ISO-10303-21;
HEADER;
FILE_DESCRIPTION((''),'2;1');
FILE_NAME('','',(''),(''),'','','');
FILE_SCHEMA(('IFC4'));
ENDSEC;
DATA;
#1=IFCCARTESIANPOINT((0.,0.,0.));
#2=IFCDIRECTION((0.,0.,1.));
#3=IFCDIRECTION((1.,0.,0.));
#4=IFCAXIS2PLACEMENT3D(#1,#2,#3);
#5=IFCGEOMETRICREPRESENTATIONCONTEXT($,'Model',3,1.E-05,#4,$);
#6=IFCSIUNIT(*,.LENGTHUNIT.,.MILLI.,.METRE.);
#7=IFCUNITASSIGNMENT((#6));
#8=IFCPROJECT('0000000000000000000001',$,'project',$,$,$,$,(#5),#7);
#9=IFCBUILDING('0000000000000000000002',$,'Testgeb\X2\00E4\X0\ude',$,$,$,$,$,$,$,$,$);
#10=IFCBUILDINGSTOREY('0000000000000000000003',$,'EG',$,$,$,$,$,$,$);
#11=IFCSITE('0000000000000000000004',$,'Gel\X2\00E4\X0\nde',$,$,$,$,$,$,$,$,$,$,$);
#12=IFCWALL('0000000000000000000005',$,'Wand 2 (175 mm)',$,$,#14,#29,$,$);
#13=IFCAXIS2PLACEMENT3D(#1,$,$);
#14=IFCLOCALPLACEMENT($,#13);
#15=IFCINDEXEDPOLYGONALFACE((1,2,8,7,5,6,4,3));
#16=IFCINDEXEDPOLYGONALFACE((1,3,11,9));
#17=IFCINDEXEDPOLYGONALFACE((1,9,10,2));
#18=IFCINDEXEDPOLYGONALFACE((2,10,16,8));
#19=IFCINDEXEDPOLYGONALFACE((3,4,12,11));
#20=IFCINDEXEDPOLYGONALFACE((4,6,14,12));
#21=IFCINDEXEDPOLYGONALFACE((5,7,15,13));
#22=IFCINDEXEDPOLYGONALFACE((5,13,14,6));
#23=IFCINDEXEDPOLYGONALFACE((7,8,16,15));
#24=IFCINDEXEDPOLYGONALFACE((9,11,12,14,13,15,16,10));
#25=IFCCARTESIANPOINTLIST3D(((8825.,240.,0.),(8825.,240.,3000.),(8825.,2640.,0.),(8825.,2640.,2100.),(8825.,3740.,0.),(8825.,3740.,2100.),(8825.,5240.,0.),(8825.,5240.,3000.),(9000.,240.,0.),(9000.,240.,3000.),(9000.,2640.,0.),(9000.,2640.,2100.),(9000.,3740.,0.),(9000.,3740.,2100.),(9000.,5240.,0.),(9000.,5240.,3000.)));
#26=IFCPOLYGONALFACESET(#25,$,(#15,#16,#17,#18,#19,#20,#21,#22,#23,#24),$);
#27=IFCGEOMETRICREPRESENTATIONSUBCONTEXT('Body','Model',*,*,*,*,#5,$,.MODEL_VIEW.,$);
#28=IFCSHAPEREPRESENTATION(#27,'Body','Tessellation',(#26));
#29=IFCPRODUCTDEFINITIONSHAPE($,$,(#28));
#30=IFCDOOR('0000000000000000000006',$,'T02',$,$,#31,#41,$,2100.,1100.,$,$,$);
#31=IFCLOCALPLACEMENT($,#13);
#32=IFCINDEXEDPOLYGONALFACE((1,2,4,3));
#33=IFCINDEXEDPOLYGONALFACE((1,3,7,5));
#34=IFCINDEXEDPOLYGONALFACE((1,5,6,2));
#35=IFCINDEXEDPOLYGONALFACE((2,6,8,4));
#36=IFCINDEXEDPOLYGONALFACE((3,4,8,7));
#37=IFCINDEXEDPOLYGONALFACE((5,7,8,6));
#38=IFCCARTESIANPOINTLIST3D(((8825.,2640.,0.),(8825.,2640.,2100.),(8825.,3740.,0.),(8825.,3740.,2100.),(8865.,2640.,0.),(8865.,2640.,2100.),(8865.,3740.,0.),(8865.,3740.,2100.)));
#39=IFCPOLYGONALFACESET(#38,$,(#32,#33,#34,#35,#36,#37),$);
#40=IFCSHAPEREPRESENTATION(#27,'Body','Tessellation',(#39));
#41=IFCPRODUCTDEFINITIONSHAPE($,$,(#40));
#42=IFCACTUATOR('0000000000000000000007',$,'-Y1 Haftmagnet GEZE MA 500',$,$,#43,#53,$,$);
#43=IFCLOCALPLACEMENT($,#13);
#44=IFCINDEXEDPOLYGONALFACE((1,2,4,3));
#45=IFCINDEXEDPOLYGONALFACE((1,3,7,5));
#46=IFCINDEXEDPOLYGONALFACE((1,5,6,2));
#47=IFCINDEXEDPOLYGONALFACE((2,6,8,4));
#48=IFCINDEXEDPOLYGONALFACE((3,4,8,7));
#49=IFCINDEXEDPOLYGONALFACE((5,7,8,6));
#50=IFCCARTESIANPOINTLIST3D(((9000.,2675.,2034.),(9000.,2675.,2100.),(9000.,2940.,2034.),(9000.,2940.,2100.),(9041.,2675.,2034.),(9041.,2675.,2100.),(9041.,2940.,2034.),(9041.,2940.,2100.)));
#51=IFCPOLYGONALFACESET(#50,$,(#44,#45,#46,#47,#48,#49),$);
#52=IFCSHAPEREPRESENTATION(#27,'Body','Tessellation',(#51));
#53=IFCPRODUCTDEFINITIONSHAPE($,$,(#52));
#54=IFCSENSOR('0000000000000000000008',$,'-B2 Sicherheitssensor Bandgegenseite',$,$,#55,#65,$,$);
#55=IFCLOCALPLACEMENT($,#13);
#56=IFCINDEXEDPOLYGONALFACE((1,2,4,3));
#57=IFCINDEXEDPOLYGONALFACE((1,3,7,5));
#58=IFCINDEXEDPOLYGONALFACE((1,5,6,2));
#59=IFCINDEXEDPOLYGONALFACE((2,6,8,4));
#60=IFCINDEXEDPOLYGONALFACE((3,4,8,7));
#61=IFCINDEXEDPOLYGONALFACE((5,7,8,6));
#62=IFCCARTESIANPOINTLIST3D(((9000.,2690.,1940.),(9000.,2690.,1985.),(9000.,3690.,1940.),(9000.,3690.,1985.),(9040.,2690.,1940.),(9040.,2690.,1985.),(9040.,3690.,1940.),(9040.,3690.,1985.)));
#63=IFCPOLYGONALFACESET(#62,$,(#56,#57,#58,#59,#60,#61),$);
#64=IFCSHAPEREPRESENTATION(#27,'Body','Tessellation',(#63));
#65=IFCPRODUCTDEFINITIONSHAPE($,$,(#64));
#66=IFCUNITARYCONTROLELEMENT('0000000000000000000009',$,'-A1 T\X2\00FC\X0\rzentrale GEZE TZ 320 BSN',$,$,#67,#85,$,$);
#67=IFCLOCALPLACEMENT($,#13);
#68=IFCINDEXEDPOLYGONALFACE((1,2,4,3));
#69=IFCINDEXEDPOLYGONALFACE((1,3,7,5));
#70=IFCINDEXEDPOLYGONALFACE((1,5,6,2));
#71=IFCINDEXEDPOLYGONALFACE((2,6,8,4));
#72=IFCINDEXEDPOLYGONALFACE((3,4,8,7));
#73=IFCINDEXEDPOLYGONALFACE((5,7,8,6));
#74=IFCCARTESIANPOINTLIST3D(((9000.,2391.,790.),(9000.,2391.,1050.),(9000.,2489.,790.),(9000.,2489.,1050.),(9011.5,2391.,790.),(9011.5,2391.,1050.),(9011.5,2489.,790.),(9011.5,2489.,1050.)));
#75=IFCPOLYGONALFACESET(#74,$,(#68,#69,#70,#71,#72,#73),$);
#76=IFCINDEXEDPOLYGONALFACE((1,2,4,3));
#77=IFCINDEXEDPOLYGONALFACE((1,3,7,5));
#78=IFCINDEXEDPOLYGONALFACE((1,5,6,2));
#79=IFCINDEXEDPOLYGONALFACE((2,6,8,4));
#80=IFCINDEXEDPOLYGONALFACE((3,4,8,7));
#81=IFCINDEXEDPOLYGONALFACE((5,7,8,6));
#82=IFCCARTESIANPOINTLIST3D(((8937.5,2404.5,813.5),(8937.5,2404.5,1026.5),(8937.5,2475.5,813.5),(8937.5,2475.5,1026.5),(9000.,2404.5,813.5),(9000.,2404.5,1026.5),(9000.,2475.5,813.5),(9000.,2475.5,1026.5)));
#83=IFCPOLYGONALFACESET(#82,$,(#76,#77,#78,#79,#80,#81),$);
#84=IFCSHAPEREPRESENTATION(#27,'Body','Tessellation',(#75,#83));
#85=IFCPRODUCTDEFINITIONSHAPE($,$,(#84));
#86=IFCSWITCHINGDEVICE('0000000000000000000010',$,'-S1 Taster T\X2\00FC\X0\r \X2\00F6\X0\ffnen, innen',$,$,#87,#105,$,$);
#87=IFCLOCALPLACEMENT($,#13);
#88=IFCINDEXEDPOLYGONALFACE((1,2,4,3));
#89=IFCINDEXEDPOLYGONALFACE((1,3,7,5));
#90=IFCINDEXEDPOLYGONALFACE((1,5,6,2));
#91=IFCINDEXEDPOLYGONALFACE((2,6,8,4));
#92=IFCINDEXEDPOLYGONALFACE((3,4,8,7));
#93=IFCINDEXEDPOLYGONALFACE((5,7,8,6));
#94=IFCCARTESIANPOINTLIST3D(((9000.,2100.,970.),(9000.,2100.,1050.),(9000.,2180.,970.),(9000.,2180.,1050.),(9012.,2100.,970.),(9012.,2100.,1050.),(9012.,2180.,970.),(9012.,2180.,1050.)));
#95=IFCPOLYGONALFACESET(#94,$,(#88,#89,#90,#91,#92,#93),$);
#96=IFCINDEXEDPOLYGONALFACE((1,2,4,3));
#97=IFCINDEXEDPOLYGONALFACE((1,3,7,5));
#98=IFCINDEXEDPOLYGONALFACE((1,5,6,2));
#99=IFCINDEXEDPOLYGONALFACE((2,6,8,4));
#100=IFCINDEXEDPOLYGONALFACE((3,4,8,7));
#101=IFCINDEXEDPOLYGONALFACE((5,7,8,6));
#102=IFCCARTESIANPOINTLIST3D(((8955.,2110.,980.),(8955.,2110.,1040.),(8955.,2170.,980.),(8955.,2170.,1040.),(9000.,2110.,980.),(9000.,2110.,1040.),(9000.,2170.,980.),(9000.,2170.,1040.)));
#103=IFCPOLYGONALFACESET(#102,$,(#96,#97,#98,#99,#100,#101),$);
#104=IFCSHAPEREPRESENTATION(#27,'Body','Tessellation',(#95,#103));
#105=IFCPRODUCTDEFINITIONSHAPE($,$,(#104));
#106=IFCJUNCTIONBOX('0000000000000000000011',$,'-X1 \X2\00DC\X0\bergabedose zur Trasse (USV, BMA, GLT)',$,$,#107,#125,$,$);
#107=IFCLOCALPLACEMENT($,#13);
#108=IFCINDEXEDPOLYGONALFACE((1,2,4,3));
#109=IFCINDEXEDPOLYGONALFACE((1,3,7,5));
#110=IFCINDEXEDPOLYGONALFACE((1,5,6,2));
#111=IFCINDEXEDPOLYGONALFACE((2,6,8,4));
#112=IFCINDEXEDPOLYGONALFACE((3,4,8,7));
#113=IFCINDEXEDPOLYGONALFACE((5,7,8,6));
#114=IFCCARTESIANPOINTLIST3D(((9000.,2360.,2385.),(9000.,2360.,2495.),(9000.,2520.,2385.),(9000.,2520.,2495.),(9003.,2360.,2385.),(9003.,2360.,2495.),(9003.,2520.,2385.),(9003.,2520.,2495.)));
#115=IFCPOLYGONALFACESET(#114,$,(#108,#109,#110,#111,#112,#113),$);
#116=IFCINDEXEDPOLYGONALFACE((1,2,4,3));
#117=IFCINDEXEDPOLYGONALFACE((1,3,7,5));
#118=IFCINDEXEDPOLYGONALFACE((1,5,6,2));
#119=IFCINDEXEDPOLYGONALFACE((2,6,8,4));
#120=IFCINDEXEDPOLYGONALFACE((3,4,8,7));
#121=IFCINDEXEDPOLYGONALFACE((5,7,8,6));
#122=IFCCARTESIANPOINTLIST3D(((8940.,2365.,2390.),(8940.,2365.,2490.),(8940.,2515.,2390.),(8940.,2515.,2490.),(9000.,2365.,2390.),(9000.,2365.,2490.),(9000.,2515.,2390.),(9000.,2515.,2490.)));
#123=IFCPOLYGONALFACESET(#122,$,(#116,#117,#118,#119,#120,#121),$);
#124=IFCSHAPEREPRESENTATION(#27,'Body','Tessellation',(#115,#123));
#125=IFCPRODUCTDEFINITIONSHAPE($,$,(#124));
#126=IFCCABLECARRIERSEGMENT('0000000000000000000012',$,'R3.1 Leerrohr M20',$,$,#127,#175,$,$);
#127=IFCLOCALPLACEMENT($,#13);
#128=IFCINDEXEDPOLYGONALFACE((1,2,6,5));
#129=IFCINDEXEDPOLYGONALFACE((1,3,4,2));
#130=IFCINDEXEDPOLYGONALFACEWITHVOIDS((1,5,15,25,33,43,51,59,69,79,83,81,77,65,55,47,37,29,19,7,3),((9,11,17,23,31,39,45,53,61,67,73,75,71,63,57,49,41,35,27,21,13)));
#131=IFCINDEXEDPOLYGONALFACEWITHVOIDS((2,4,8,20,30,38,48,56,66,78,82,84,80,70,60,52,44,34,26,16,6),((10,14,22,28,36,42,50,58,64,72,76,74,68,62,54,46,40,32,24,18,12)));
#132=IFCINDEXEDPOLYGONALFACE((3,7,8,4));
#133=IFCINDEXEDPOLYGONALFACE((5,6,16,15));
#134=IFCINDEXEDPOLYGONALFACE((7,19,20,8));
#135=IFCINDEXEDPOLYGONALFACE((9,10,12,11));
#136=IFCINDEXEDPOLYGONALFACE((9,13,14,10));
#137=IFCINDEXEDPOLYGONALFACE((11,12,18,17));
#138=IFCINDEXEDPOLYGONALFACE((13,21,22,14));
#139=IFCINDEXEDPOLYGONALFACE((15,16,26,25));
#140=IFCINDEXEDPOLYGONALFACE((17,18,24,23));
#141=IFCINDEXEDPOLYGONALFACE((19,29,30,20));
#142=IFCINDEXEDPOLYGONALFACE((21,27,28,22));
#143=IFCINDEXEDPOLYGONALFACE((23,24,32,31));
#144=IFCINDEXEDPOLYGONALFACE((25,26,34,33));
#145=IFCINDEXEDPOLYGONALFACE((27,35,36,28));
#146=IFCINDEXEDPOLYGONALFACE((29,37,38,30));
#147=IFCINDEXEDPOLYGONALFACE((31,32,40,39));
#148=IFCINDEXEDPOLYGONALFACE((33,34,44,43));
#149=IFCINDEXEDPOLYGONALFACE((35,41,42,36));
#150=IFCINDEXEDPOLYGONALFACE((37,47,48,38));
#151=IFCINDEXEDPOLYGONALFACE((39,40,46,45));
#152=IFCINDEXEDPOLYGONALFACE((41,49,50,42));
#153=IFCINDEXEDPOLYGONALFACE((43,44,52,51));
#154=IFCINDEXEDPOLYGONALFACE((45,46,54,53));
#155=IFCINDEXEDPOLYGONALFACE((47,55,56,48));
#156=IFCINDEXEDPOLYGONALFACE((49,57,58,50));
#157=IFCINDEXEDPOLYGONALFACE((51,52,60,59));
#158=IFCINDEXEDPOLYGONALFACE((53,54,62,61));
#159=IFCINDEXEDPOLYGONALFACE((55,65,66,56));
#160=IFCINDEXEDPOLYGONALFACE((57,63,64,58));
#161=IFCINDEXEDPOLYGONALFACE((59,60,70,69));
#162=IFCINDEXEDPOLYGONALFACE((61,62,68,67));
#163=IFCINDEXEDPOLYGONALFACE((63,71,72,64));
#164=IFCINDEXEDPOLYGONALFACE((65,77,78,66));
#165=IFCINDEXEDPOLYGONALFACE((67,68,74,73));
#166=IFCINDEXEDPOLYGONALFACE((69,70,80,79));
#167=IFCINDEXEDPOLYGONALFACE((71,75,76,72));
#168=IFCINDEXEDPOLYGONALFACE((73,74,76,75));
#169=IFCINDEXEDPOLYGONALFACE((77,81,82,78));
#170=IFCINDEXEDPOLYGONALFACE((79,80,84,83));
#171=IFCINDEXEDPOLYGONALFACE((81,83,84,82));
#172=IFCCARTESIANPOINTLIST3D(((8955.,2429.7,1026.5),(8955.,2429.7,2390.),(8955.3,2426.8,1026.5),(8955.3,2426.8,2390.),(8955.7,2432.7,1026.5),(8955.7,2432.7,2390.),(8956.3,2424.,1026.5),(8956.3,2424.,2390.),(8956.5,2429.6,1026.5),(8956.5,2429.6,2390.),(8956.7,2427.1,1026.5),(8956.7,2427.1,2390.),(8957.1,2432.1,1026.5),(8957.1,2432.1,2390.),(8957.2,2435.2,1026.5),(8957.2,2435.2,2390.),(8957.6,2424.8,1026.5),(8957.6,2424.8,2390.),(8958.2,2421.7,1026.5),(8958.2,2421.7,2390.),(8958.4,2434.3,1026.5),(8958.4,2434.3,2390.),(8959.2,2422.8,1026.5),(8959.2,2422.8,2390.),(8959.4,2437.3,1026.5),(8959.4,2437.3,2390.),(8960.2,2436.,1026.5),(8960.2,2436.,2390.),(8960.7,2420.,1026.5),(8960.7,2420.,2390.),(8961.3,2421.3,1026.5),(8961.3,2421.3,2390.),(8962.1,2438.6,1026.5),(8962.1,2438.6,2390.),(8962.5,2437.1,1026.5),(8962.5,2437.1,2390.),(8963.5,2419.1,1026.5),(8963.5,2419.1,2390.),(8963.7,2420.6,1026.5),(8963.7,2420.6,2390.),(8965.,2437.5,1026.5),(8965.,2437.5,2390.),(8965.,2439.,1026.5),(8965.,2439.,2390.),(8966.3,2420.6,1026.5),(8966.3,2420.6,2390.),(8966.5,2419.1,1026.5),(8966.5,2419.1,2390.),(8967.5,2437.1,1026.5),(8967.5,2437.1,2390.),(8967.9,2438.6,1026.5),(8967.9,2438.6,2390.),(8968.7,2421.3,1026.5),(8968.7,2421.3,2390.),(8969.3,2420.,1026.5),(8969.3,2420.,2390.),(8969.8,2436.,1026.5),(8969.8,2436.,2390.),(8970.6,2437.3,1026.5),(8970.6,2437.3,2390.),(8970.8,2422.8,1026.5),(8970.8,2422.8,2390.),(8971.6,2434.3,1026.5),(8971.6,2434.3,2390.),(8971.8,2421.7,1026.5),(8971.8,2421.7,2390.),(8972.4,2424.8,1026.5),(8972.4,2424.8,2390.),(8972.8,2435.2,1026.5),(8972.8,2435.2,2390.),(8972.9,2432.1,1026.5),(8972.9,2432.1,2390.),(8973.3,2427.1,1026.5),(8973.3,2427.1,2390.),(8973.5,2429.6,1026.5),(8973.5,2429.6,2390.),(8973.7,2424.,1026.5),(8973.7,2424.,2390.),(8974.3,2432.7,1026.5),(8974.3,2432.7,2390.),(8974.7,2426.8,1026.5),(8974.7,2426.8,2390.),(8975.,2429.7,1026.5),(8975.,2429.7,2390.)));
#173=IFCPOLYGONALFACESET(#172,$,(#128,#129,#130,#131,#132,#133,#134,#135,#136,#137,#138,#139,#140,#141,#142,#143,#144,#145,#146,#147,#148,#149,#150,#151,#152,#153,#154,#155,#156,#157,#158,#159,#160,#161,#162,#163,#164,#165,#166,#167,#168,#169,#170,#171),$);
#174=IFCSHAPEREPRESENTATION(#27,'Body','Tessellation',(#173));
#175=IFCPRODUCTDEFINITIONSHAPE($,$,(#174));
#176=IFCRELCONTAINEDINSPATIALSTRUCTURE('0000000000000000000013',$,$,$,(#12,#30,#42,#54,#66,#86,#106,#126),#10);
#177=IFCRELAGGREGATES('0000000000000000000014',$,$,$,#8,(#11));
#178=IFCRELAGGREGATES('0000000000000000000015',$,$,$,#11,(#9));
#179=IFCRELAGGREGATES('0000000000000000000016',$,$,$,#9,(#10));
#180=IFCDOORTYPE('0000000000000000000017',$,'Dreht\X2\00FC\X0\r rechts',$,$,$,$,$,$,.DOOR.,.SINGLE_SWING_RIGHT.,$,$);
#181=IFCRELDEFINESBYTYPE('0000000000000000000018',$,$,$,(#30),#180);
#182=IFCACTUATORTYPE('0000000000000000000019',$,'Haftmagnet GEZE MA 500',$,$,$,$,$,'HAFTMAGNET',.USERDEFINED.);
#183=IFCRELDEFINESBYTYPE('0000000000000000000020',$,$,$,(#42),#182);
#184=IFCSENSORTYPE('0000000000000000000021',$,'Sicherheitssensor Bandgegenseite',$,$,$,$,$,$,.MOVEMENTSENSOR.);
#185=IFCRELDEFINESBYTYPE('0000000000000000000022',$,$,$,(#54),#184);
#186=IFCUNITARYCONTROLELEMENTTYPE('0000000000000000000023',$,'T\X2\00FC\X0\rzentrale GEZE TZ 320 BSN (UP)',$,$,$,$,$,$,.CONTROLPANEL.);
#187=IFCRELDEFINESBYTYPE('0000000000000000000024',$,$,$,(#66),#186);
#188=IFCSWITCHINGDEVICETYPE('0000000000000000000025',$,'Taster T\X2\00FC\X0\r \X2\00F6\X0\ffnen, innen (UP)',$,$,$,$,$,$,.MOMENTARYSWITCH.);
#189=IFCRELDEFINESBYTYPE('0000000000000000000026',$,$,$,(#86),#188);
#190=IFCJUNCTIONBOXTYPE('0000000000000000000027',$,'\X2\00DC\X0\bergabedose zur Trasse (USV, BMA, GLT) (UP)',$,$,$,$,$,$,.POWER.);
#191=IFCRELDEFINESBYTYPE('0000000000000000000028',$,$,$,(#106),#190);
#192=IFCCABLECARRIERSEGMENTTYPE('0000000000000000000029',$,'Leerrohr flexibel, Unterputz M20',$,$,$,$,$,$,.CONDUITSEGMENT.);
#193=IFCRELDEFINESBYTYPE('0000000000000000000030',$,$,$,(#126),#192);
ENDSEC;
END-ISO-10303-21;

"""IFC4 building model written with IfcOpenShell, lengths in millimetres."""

from ifc_helpers import new_model, si_unit, frame, frame_2d, origin_with_axes, place, context, subcontext, project, spatial, rectangle, hollow_circle, extrude, type_object, element, fill, save


model = new_model("IFC4")

# Units and contexts
model_context = context("Model", 3, precision=1e-05, world=origin_with_axes())
body_context = subcontext(model_context, "Body", "Model", "MODEL_VIEW")
ifc_project = project(units=[si_unit("LENGTHUNIT", "METRE", prefix="MILLI")], contexts=[model_context])

# Site, building, storey
site = spatial("IfcSite", under=ifc_project, Name="Gelände")
building = spatial("IfcBuilding", under=site, Name="Testgebäude")
storey = spatial("IfcBuildingStorey", under=building, Name="EG")

# Wall, opening, door
wall_placement = place(None, frame((9000.0, 240.0, 0.0), z_axis=(0.0, 0.0, 1.0), x_axis=(0.0, 1.0, 0.0)))
wall = element("IfcWall", 1, at=wall_placement, inside=storey, Name="Wand 2 (175 mm)", context=body_context, shape_type="SweptSolid", body=[
    extrude(rectangle(XDim=5000.0, YDim=175.0, at=frame_2d((2500.0, 87.5))), None, (0.0, 0.0, 1.0), 3000.0),
])
opening_placement = place(None, frame((9000.0, 2640.0, 0.0), z_axis=(0.0, 0.0, 1.0), x_axis=(0.0, 1.0, 0.0)))
opening = element("IfcOpeningElement", 2, at=opening_placement, cuts=wall, context=body_context, shape_type="SweptSolid", body=[
    extrude(rectangle(XDim=1100.0, YDim=175.0, at=frame_2d((550.0, 87.5))), None, (0.0, 0.0, 1.0), 2100.0),
])
door_type = type_object("IfcDoorType", Name="Drehtür rechts", OperationType="SINGLE_SWING_RIGHT", PredefinedType="DOOR")
door_placement = place(opening_placement, origin_with_axes())
door = element("IfcDoor", 3, at=door_placement, inside=storey, type_object=door_type, Name="T02", OverallHeight=2100.0, OverallWidth=1100.0, context=body_context, shape_type="SweptSolid", body=[
    extrude(rectangle(XDim=1100.0, YDim=40.0, at=frame_2d((550.0, 20.0))), frame((0.0, 135.0, 0.0)), (0.0, 0.0, 1.0), 2100.0),
])
fill(opening, door)

# Actuator
actuator_type = type_object("IfcActuatorType", Name="Haftmagnet GEZE MA 500", ElementType="HAFTMAGNET", PredefinedType="USERDEFINED")
actuator_placement = place(None, frame((9041.0, 2675.0, 2034.0), z_axis=(0.0, 0.0, 1.0), x_axis=(0.0, 1.0, 0.0)))
element("IfcActuator", 4, at=actuator_placement, inside=storey, type_object=actuator_type, Name="-Y1 Haftmagnet GEZE MA 500", context=body_context, shape_type="SweptSolid", body=[
    extrude(rectangle(XDim=265.0, YDim=41.0, at=frame_2d((132.5, 20.5))), None, (0.0, 0.0, 1.0), 66.0),
])

# Sensor
sensor_type = type_object("IfcSensorType", Name="Sicherheitssensor Bandgegenseite", PredefinedType="MOVEMENTSENSOR")
sensor_placement = place(None, frame((9040.0, 2690.0, 1940.0), z_axis=(0.0, 0.0, 1.0), x_axis=(0.0, 1.0, 0.0)))
element("IfcSensor", 5, at=sensor_placement, inside=storey, type_object=sensor_type, Name="-B2 Sicherheitssensor Bandgegenseite", context=body_context, shape_type="SweptSolid", body=[
    extrude(rectangle(XDim=1000.0, YDim=40.0, at=frame_2d((500.0, 20.0))), None, (0.0, 0.0, 1.0), 45.0),
])

# Unitary control element
unitary_control_element_type = type_object("IfcUnitaryControlElementType", Name="Türzentrale GEZE TZ 320 BSN (UP)", PredefinedType="CONTROLPANEL")
unitary_control_element_placement = place(None, frame((9011.5, 2391.0, 790.0), z_axis=(0.0, 0.0, 1.0), x_axis=(0.0, 1.0, 0.0)))
element("IfcUnitaryControlElement", 6, at=unitary_control_element_placement, inside=storey, type_object=unitary_control_element_type, Name="-A1 Türzentrale GEZE TZ 320 BSN", context=body_context, shape_type="SweptSolid", body=[
    extrude(rectangle(XDim=98.0, YDim=11.5, at=frame_2d((49.0, 5.8))), None, (0.0, 0.0, 1.0), 260.0),
    extrude(rectangle(XDim=71.0, YDim=62.5, at=frame_2d((35.5, 31.2))), frame((13.5, 11.5, 23.5), z_axis=(0.0, 0.0, 1.0), x_axis=(1.0, 0.0, 0.0)), (0.0, 0.0, 1.0), 213.0),
])

# Switching device
switching_device_type = type_object("IfcSwitchingDeviceType", Name="Taster Tür öffnen, innen (UP)", PredefinedType="MOMENTARYSWITCH")
switching_device_placement = place(None, frame((9012.0, 2100.0, 970.0), z_axis=(0.0, 0.0, 1.0), x_axis=(0.0, 1.0, 0.0)))
element("IfcSwitchingDevice", 7, at=switching_device_placement, inside=storey, type_object=switching_device_type, Name="-S1 Taster Tür öffnen, innen", context=body_context, shape_type="SweptSolid", body=[
    extrude(rectangle(XDim=80.0, YDim=12.0, at=frame_2d((40.0, 6.0))), None, (0.0, 0.0, 1.0), 80.0),
    extrude(rectangle(XDim=60.0, YDim=45.0, at=frame_2d((30.0, 22.5))), frame((10.0, 12.0, 10.0), z_axis=(0.0, 0.0, 1.0), x_axis=(1.0, 0.0, 0.0)), (0.0, 0.0, 1.0), 60.0),
])

# Junction box
junction_box_type = type_object("IfcJunctionBoxType", Name="Übergabedose zur Trasse (USV, BMA, GLT) (UP)", PredefinedType="POWER")
junction_box_placement = place(None, frame((9003.0, 2360.0, 2385.0), z_axis=(0.0, 0.0, 1.0), x_axis=(0.0, 1.0, 0.0)))
element("IfcJunctionBox", 8, at=junction_box_placement, inside=storey, type_object=junction_box_type, Name="-X1 Übergabedose zur Trasse (USV, BMA, GLT)", context=body_context, shape_type="SweptSolid", body=[
    extrude(rectangle(XDim=160.0, YDim=3.0, at=frame_2d((80.0, 1.5))), None, (0.0, 0.0, 1.0), 110.0),
    extrude(rectangle(XDim=150.0, YDim=60.0, at=frame_2d((75.0, 30.0))), frame((5.0, 3.0, 5.0), z_axis=(0.0, 0.0, 1.0), x_axis=(1.0, 0.0, 0.0)), (0.0, 0.0, 1.0), 100.0),
])

# Cable carrier segment
cable_carrier_segment_type_1 = type_object("IfcCableCarrierSegmentType", Name="Leerrohr flexibel, Unterputz M20", PredefinedType="CONDUITSEGMENT")
for number, where, z_axis, x_axis, name in (
    (9, (8965.0, 2429.0, 1026.5), (0.0, 0.0, 1.0), (0.0, 1.0, 0.0), "R3.1 Leerrohr M20"),
):
    element("IfcCableCarrierSegment", number, at=place(None, frame(where, z_axis=z_axis, x_axis=x_axis)), inside=storey, type_object=cable_carrier_segment_type_1, Name=name, context=body_context, shape_type="SweptSolid", body=[
        extrude(hollow_circle(Radius=10.0, WallThickness=1.5), None, (0.0, 0.0, 1.0), 1363.5),
    ])

save(model, "model.ifc")
